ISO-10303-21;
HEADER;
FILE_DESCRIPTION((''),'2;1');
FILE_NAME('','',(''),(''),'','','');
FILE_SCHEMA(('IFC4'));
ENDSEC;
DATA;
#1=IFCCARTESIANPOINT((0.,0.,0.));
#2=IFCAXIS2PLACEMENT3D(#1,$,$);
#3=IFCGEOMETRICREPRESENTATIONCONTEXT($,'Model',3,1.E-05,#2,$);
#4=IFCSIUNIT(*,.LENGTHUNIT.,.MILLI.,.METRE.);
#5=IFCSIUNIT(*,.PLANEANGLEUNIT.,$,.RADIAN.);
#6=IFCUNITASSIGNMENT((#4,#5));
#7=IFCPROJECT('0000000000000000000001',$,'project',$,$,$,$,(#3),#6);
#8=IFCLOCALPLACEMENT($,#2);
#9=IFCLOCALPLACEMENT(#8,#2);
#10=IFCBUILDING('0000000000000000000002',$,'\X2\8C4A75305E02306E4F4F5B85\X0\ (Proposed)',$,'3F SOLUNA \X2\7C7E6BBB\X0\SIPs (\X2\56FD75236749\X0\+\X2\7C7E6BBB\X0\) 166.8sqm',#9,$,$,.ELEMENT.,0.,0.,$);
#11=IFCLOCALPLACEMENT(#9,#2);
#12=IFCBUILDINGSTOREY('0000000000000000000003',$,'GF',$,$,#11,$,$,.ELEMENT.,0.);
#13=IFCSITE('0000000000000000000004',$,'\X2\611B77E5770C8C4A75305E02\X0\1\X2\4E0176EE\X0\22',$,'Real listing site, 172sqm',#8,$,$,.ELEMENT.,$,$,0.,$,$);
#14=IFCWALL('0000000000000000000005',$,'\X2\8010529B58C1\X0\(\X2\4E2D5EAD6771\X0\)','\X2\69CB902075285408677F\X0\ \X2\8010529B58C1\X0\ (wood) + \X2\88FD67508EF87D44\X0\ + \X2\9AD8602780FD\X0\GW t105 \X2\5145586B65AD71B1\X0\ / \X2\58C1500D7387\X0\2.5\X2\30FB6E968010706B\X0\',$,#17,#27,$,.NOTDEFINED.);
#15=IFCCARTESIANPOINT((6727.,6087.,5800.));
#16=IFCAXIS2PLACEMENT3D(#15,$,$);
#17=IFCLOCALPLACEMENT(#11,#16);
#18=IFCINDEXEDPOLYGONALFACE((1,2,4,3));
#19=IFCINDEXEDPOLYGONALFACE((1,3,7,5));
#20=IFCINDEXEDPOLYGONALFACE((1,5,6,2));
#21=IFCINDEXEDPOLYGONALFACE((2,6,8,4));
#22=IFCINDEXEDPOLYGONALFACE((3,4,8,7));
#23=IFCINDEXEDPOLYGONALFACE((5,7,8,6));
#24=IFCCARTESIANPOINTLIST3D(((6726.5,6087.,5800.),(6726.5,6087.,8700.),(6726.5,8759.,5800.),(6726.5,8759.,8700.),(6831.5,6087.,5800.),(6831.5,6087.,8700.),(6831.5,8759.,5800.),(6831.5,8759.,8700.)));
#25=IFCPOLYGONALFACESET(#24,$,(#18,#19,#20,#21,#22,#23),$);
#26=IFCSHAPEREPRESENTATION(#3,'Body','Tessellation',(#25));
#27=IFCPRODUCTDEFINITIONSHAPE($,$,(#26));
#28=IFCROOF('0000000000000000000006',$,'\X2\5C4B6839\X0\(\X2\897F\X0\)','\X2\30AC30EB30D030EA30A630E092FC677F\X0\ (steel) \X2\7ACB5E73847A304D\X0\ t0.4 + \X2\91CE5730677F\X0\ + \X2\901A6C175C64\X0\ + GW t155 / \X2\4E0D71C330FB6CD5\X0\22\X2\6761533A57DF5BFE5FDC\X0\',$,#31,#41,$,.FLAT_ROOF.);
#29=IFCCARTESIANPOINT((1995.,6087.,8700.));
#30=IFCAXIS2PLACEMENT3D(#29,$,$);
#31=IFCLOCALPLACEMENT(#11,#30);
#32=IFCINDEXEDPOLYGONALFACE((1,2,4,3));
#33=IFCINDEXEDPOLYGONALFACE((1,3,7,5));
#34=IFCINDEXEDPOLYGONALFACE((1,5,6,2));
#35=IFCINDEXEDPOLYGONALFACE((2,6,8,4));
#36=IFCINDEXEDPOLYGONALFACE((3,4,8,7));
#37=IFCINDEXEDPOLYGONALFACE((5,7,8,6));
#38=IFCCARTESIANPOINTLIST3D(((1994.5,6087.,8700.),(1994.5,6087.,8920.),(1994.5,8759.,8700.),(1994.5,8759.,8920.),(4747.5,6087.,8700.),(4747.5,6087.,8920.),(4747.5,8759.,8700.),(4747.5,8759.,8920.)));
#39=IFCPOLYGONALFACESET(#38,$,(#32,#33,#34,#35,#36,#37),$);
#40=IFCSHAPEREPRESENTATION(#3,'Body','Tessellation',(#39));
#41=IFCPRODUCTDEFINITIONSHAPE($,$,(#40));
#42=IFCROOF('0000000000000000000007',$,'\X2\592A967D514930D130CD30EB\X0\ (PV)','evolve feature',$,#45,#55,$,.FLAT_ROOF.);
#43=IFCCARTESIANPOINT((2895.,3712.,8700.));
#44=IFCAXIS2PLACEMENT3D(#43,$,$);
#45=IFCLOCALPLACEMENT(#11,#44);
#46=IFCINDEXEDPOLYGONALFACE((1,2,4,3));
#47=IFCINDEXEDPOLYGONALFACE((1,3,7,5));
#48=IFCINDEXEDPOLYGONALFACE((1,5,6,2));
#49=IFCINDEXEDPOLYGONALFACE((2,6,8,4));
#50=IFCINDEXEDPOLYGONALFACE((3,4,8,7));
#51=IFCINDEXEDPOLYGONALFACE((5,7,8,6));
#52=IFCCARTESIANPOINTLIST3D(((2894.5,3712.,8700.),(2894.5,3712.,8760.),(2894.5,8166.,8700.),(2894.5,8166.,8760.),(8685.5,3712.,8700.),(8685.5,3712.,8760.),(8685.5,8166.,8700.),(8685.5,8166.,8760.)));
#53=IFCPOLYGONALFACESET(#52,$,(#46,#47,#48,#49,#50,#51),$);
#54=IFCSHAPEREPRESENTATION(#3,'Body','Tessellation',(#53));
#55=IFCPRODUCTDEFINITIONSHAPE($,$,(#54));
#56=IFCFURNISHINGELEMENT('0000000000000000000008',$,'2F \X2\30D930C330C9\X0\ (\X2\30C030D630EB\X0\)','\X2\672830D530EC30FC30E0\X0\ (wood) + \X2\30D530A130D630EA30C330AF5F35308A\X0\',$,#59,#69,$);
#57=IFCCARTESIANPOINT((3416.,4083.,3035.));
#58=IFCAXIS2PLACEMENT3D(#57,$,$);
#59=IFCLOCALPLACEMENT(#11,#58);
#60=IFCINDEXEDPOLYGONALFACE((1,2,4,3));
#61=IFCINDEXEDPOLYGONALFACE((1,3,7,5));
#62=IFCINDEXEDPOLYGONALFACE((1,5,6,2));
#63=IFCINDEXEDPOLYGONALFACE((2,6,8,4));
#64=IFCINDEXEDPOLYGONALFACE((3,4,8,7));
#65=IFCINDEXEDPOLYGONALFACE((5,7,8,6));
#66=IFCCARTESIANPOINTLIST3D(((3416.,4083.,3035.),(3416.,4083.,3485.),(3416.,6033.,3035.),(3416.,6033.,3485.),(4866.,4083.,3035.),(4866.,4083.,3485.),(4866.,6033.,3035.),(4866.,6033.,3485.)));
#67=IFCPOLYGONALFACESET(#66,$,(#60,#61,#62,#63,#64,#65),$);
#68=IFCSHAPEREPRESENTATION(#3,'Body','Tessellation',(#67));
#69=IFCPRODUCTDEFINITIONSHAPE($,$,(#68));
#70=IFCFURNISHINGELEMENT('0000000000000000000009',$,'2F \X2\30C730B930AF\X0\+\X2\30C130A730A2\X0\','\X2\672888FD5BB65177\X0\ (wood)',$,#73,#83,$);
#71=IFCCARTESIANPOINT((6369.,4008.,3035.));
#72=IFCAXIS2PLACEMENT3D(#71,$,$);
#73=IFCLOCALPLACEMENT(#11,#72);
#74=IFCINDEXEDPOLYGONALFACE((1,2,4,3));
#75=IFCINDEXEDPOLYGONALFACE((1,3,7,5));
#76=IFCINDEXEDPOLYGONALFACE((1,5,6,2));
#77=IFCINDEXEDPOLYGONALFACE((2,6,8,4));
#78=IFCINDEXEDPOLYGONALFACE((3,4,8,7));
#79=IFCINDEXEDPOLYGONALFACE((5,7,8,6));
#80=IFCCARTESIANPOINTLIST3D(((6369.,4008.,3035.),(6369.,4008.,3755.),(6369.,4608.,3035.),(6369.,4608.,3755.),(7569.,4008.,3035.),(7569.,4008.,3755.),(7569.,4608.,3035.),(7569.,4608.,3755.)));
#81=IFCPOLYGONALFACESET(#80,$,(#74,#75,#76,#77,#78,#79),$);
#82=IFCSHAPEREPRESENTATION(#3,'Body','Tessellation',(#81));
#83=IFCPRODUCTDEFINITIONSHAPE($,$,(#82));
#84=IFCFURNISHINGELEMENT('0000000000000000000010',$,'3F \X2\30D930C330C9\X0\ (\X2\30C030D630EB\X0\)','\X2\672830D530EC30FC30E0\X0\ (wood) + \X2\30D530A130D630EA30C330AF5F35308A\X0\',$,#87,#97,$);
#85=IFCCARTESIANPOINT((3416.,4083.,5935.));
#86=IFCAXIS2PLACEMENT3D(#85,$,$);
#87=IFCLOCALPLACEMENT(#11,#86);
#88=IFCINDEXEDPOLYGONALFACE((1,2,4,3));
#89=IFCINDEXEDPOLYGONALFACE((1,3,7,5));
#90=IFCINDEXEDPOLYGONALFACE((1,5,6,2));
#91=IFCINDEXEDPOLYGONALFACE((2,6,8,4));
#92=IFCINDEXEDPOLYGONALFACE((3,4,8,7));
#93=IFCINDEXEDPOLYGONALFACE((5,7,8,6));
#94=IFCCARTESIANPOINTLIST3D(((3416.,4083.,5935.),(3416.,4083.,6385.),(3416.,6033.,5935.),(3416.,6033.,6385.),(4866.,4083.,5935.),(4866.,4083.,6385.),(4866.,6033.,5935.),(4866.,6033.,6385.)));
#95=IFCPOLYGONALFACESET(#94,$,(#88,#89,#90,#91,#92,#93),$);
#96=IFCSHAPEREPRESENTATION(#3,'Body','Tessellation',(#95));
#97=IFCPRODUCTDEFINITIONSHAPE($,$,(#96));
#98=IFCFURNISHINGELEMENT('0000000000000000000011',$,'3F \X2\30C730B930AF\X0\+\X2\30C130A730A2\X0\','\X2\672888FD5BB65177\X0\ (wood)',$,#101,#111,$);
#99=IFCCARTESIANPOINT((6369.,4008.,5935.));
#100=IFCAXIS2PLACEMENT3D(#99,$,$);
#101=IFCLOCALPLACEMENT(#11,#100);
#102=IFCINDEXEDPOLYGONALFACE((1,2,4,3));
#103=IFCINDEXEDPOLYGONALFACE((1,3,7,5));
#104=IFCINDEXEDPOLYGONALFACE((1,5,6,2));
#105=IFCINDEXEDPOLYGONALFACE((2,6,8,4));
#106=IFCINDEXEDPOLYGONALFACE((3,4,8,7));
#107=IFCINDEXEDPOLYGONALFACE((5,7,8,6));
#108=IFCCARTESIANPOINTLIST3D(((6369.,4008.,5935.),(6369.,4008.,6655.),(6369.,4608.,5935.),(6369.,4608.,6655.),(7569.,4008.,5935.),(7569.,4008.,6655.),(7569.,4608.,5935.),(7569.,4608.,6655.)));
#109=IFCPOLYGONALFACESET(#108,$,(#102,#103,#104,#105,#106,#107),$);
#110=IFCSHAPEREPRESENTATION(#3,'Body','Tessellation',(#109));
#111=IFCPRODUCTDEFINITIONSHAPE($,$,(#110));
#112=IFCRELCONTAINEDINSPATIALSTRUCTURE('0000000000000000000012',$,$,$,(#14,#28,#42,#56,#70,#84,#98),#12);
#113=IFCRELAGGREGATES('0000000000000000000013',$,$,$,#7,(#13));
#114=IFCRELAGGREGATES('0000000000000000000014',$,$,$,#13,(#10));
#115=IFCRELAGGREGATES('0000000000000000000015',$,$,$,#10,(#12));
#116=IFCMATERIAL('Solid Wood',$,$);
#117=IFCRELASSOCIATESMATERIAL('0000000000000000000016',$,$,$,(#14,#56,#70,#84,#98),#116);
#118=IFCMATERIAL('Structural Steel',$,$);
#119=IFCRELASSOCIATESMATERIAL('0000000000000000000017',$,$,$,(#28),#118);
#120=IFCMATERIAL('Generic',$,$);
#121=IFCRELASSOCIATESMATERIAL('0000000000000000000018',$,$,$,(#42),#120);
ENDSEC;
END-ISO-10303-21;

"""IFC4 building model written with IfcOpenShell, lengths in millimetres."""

from ifc_helpers import new_model, si_unit, frame, frame_2d, origin, place, context, project, spatial, rectangle, extrude, material, element, save


model = new_model("IFC4")

# Units and contexts
model_context = context("Model", 3, precision=1e-05, world=origin())
ifc_project = project(units=[si_unit("LENGTHUNIT", "METRE", prefix="MILLI"), si_unit("PLANEANGLEUNIT", "RADIAN")], contexts=[model_context])

# Site, building, storey
site_placement = place(None, origin())
site = spatial("IfcSite", under=ifc_project, at=site_placement, Name="愛知県豊田市1丁目22", ObjectType="Real listing site, 172sqm", CompositionType="ELEMENT", RefElevation=0.0)
building_placement = place(site_placement, origin())
building = spatial("IfcBuilding", under=site, at=building_placement, Name="豊田市の住宅 (Proposed)", ObjectType="3F SOLUNA 籾殻SIPs (国産杉+籾殻) 166.8sqm", CompositionType="ELEMENT", ElevationOfRefHeight=0.0, ElevationOfTerrain=0.0)
storey_placement = place(building_placement, origin())
storey = spatial("IfcBuildingStorey", under=building, at=storey_placement, Name="GF", CompositionType="ELEMENT", Elevation=0.0)

# Shared definitions
ifc_material_1 = material(Name="Solid Wood")

# Wall
wall_1_placement = place(storey_placement, frame((6727.0, 6087.0, 5800.0)))
element("IfcWall", 1, at=wall_1_placement, inside=storey, material=ifc_material_1, Name="耐力壁(中庭東)", Description="構造用合板 耐力壁 (wood) + 製材軸組 + 高性能GW t105 充填断熱 / 壁倍率2.5・準耐火", PredefinedType="NOTDEFINED", context=model_context, shape_type="SweptSolid", body=[
    extrude(rectangle(XDim=105.0, YDim=2672.0, at=frame_2d((52.0, 1336.0))), frame((6727.0, 6087.0, 5800.0)), (0.0, 0.0, 1.0), 2900.0),
])

# Roofs
ifc_material_2 = material(Name="Structural Steel")
roof_1_placement = place(storey_placement, frame((1995.0, 6087.0, 8700.0)))
element("IfcRoof", 2, at=roof_1_placement, inside=storey, material=ifc_material_2, Name="屋根(西)", Description="ガルバリウム鋼板 (steel) 立平葺き t0.4 + 野地板 + 通気層 + GW t155 / 不燃・法22条区域対応", PredefinedType="FLAT_ROOF", context=model_context, shape_type="SweptSolid", body=[
    extrude(rectangle(XDim=2753.0, YDim=2672.0, at=frame_2d((1376.0, 1336.0))), frame((1995.0, 6087.0, 8700.0)), (0.0, 0.0, 1.0), 220.0),
])
ifc_material_3 = material(Name="Generic")
roof_2_placement = place(storey_placement, frame((2895.0, 3712.0, 8700.0)))
element("IfcRoof", 3, at=roof_2_placement, inside=storey, material=ifc_material_3, Name="太陽光パネル (PV)", Description="evolve feature", PredefinedType="FLAT_ROOF", context=model_context, shape_type="SweptSolid", body=[
    extrude(rectangle(XDim=5791.0, YDim=4454.0, at=frame_2d((2895.0, 2227.0))), frame((2895.0, 3712.0, 8700.0)), (0.0, 0.0, 1.0), 60.0),
])

# Furnishing elements
furnishing_1_placement = place(storey_placement, frame((3416.0, 4083.0, 3035.0)))
element("IfcFurnishingElement", 4, at=furnishing_1_placement, inside=storey, material=ifc_material_1, Name="2F ベッド (ダブル)", Description="木フレーム (wood) + ファブリック張り", context=model_context, shape_type="SweptSolid", body=[
    extrude(rectangle(XDim=1450.0, YDim=1950.0, at=frame_2d((725.0, 975.0))), frame((3416.0, 4083.0, 3035.0)), (0.0, 0.0, 1.0), 450.0),
])
furnishing_2_placement = place(storey_placement, frame((6369.0, 4008.0, 3035.0)))
element("IfcFurnishingElement", 5, at=furnishing_2_placement, inside=storey, material=ifc_material_1, Name="2F デスク+チェア", Description="木製家具 (wood)", context=model_context, shape_type="SweptSolid", body=[
    extrude(rectangle(XDim=1200.0, YDim=600.0, at=frame_2d((600.0, 300.0))), frame((6369.0, 4008.0, 3035.0)), (0.0, 0.0, 1.0), 720.0),
])
furnishing_3_placement = place(storey_placement, frame((3416.0, 4083.0, 5935.0)))
element("IfcFurnishingElement", 6, at=furnishing_3_placement, inside=storey, material=ifc_material_1, Name="3F ベッド (ダブル)", Description="木フレーム (wood) + ファブリック張り", context=model_context, shape_type="SweptSolid", body=[
    extrude(rectangle(XDim=1450.0, YDim=1950.0, at=frame_2d((725.0, 975.0))), frame((3416.0, 4083.0, 5935.0)), (0.0, 0.0, 1.0), 450.0),
])
furnishing_4_placement = place(storey_placement, frame((6369.0, 4008.0, 5935.0)))
element("IfcFurnishingElement", 7, at=furnishing_4_placement, inside=storey, material=ifc_material_1, Name="3F デスク+チェア", Description="木製家具 (wood)", context=model_context, shape_type="SweptSolid", body=[
    extrude(rectangle(XDim=1200.0, YDim=600.0, at=frame_2d((600.0, 300.0))), frame((6369.0, 4008.0, 5935.0)), (0.0, 0.0, 1.0), 720.0),
])

save(model, "model.ifc")
